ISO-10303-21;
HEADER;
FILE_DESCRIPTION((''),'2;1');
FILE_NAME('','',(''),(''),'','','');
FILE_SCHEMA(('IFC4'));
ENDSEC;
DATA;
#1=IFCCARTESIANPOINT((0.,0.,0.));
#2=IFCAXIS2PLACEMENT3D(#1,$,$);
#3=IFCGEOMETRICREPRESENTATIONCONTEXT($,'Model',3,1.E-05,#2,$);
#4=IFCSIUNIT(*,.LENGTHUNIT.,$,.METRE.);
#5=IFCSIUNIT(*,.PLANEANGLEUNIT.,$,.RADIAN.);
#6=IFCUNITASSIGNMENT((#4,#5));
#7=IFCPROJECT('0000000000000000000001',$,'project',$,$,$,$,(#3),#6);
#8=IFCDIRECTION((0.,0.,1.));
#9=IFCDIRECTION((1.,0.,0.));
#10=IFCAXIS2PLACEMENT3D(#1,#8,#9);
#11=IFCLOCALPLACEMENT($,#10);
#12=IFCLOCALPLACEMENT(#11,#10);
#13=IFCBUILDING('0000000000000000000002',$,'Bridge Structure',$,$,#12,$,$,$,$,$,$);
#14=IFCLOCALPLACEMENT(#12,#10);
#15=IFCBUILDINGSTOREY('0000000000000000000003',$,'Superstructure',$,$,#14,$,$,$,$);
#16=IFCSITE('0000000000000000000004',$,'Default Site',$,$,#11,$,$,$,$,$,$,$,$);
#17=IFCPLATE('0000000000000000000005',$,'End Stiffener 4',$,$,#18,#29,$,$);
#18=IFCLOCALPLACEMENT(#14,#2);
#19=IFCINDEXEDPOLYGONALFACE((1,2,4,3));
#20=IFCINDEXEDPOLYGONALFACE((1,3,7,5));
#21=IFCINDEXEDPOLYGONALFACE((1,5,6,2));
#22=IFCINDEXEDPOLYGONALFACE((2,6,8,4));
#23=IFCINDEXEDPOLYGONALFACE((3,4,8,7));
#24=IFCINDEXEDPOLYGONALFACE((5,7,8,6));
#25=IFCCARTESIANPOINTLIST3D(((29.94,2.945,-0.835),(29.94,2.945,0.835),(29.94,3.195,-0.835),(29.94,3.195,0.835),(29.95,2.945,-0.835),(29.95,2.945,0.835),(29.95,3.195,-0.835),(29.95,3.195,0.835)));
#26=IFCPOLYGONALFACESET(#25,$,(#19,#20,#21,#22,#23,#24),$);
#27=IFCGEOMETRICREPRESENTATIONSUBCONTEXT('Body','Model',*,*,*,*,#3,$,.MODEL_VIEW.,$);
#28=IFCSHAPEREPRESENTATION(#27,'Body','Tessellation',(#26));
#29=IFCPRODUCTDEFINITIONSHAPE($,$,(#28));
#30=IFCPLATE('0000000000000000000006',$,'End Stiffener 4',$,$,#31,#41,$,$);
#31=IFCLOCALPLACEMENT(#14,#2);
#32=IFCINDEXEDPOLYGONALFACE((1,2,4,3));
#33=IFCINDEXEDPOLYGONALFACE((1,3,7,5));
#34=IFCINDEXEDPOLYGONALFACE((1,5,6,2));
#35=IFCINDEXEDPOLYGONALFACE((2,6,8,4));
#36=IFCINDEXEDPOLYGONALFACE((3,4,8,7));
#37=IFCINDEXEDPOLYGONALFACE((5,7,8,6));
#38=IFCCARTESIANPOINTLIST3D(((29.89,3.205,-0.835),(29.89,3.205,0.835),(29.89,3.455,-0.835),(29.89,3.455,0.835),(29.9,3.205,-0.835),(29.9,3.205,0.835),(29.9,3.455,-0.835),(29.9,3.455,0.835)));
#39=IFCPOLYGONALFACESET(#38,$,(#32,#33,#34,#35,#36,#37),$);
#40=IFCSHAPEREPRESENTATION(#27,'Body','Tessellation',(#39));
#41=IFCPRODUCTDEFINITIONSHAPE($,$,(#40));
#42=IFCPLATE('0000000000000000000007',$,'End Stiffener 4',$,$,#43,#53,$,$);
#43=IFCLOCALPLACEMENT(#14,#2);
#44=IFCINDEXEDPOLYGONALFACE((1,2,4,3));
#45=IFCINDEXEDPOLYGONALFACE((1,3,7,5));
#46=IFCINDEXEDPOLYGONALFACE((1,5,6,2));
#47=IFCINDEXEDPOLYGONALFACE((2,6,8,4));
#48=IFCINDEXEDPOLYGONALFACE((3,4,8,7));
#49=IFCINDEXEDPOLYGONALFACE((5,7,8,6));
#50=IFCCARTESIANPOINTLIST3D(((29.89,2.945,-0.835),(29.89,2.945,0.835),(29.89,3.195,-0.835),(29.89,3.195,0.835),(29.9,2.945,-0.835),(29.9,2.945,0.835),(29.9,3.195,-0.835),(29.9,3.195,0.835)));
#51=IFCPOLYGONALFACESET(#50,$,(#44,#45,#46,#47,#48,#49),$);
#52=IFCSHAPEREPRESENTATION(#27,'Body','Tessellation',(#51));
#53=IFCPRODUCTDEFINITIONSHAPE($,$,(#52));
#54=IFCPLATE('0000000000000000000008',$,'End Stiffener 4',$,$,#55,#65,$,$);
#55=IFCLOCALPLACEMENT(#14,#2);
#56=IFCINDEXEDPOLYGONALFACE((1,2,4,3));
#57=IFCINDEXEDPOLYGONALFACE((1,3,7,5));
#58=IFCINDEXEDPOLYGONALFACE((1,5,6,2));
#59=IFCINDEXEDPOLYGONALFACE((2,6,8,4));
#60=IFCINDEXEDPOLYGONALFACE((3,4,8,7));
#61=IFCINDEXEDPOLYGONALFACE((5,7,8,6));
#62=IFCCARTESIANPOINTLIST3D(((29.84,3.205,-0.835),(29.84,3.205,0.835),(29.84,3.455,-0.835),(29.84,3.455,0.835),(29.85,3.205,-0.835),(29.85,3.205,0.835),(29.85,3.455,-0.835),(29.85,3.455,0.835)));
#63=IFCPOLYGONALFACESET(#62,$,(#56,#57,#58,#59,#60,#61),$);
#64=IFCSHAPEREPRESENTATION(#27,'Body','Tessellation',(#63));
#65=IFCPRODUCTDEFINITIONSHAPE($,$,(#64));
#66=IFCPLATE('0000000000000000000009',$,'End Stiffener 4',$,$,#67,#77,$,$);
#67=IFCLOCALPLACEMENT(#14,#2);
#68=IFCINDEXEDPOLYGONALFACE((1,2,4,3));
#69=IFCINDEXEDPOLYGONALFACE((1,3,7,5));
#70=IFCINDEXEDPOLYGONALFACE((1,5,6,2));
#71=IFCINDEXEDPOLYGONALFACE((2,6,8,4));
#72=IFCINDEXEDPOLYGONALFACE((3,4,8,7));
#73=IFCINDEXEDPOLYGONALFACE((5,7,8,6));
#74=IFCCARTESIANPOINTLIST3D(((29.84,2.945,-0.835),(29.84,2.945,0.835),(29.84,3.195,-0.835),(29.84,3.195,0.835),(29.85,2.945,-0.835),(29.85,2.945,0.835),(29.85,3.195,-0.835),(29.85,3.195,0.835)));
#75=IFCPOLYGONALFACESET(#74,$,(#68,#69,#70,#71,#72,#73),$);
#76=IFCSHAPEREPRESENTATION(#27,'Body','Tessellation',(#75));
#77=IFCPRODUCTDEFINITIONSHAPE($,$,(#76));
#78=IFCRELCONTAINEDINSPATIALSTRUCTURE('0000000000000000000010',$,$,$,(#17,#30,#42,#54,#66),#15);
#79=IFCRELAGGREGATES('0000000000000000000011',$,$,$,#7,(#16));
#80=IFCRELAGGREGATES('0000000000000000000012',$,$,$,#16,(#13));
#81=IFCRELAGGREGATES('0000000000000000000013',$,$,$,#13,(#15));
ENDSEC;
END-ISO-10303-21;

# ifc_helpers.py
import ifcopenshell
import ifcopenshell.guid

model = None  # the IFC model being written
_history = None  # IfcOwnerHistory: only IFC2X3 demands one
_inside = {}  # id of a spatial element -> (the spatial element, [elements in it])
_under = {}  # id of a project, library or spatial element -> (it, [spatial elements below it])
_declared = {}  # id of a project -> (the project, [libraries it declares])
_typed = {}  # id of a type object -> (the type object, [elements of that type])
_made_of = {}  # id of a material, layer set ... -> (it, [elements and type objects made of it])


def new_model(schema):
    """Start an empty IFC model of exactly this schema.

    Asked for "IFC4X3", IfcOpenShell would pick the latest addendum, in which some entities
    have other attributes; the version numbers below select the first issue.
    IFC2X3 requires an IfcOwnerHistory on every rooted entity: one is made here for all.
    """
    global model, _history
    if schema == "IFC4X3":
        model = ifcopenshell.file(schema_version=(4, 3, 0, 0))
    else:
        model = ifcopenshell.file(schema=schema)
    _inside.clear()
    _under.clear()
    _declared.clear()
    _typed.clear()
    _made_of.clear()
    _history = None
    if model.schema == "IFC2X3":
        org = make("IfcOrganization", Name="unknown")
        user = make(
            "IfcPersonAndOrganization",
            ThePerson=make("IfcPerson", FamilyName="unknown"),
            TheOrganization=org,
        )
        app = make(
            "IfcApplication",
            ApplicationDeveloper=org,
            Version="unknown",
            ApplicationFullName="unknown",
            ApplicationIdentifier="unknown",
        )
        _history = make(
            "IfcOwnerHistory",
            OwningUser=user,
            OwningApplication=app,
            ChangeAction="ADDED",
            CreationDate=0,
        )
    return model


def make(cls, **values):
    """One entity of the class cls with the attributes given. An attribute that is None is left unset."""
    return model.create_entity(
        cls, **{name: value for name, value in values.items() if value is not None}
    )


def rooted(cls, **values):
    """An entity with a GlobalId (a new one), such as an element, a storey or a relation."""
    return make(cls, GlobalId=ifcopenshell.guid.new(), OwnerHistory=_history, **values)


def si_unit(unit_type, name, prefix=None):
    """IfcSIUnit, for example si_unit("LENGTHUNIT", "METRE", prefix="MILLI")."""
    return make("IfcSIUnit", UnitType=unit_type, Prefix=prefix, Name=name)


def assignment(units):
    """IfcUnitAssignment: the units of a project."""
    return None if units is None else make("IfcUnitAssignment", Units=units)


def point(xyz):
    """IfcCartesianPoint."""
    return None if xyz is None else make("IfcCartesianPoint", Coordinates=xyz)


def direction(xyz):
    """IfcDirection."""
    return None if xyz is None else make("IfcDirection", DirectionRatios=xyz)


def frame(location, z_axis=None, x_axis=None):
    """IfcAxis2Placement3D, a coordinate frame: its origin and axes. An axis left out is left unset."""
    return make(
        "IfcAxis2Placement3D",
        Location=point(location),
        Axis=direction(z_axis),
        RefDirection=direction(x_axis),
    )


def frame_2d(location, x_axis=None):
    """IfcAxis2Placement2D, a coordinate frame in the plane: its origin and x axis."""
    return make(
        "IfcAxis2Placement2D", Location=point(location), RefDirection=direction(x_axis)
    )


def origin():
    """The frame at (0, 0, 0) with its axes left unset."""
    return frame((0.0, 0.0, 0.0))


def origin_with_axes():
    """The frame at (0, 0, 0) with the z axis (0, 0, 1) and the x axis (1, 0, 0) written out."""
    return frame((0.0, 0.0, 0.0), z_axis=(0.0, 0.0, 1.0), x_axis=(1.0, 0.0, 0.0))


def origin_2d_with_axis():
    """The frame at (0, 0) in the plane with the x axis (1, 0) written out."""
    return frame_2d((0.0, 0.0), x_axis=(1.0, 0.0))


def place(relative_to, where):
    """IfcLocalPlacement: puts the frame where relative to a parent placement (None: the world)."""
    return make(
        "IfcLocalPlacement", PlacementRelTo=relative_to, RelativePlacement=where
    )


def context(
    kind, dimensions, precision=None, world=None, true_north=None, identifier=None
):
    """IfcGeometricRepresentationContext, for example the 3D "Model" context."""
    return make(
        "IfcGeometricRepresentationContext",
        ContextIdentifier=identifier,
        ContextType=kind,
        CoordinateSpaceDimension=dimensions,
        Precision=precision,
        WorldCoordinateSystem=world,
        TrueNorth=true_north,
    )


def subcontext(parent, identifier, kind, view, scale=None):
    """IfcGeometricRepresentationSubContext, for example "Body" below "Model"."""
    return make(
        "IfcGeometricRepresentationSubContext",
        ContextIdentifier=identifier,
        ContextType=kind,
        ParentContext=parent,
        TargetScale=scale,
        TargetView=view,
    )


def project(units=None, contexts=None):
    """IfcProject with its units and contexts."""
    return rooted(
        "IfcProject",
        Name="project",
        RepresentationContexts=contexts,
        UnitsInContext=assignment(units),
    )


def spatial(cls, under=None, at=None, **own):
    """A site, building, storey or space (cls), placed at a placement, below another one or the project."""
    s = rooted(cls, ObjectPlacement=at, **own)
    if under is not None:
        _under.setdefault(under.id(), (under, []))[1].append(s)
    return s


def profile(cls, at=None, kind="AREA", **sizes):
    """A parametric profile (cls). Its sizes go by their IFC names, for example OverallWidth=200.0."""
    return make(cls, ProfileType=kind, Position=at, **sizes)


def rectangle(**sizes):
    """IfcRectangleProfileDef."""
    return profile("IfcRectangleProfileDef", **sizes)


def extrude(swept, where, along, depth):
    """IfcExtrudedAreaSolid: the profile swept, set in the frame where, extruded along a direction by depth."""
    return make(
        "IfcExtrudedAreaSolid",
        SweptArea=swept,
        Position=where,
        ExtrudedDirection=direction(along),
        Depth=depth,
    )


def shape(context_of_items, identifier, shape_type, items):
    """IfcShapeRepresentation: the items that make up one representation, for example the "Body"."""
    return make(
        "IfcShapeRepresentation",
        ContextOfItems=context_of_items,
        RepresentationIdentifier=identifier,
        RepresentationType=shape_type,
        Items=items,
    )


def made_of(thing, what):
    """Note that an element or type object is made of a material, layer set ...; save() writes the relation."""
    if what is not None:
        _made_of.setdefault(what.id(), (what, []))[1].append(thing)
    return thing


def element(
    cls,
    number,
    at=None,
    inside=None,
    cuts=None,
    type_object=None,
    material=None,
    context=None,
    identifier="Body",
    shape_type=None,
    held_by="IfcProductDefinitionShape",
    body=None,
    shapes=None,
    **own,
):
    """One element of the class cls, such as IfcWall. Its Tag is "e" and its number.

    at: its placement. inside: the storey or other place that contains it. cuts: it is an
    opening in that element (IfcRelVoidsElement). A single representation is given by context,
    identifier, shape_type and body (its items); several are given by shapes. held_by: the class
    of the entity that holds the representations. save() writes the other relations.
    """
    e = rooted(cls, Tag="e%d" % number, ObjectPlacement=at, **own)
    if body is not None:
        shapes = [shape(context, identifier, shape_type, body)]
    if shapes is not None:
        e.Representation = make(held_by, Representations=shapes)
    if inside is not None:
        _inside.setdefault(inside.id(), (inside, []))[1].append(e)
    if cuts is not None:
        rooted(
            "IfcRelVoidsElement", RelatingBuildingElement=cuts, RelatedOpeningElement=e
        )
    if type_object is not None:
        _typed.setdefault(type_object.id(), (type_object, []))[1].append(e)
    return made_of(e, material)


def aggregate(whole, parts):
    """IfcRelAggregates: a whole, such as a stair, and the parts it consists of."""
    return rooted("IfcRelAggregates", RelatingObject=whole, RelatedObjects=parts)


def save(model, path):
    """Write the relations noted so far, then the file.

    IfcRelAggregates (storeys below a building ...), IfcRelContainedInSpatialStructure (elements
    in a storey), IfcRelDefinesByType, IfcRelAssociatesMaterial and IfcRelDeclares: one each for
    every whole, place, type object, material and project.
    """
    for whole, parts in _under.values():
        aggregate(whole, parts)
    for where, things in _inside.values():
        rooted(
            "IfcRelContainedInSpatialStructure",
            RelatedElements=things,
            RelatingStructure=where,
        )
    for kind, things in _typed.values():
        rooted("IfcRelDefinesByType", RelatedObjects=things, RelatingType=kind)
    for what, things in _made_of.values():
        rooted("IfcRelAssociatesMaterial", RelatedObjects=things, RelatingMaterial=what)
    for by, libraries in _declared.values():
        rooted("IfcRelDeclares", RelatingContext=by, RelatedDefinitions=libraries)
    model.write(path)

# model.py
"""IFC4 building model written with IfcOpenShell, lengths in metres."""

from ifc_helpers import new_model, si_unit, frame, origin, origin_with_axes, origin_2d_with_axis, place, context, subcontext, project, spatial, rectangle, extrude, element, save


model = new_model("IFC4")

# Units and contexts
model_context = context("Model", 3, precision=1e-05, world=origin())
body_context = subcontext(model_context, "Body", "Model", "MODEL_VIEW")
ifc_project = project(units=[si_unit("LENGTHUNIT", "METRE"), si_unit("PLANEANGLEUNIT", "RADIAN")], contexts=[model_context])

# Site, building, storey
site_placement = place(None, origin_with_axes())
site = spatial("IfcSite", under=ifc_project, at=site_placement, Name="Default Site")
building_placement = place(site_placement, origin_with_axes())
building = spatial("IfcBuilding", under=site, at=building_placement, Name="Bridge Structure")
storey_placement = place(building_placement, origin_with_axes())
storey = spatial("IfcBuildingStorey", under=building, at=storey_placement, Name="Superstructure")

# Plates
for number, where, z_axis, x_axis, name in (
    (1, (29.945, 3.07, -0.835), (0.0, 0.0, 1.0), (1.0, 0.0, 0.0), "End Stiffener 4"),
    (2, (29.895, 3.33, -0.835), (0.0, 0.0, 1.0), (1.0, 0.0, 0.0), "End Stiffener 4"),
    (3, (29.895, 3.07, -0.835), (0.0, 0.0, 1.0), (1.0, 0.0, 0.0), "End Stiffener 4"),
    (4, (29.845, 3.33, -0.835), (0.0, 0.0, 1.0), (1.0, 0.0, 0.0), "End Stiffener 4"),
    (5, (29.845, 3.07, -0.835), (0.0, 0.0, 1.0), (1.0, 0.0, 0.0), "End Stiffener 4"),
):
    element("IfcPlate", number, at=place(storey_placement, frame(where, z_axis=z_axis, x_axis=x_axis)), inside=storey, Name=name, context=body_context, shape_type="SweptSolid", body=[
        extrude(rectangle(XDim=0.01, YDim=0.25, at=origin_2d_with_axis()), origin_with_axes(), (0.0, 0.0, 1.0), 1.67),
    ])

save(model, "model.ifc")
